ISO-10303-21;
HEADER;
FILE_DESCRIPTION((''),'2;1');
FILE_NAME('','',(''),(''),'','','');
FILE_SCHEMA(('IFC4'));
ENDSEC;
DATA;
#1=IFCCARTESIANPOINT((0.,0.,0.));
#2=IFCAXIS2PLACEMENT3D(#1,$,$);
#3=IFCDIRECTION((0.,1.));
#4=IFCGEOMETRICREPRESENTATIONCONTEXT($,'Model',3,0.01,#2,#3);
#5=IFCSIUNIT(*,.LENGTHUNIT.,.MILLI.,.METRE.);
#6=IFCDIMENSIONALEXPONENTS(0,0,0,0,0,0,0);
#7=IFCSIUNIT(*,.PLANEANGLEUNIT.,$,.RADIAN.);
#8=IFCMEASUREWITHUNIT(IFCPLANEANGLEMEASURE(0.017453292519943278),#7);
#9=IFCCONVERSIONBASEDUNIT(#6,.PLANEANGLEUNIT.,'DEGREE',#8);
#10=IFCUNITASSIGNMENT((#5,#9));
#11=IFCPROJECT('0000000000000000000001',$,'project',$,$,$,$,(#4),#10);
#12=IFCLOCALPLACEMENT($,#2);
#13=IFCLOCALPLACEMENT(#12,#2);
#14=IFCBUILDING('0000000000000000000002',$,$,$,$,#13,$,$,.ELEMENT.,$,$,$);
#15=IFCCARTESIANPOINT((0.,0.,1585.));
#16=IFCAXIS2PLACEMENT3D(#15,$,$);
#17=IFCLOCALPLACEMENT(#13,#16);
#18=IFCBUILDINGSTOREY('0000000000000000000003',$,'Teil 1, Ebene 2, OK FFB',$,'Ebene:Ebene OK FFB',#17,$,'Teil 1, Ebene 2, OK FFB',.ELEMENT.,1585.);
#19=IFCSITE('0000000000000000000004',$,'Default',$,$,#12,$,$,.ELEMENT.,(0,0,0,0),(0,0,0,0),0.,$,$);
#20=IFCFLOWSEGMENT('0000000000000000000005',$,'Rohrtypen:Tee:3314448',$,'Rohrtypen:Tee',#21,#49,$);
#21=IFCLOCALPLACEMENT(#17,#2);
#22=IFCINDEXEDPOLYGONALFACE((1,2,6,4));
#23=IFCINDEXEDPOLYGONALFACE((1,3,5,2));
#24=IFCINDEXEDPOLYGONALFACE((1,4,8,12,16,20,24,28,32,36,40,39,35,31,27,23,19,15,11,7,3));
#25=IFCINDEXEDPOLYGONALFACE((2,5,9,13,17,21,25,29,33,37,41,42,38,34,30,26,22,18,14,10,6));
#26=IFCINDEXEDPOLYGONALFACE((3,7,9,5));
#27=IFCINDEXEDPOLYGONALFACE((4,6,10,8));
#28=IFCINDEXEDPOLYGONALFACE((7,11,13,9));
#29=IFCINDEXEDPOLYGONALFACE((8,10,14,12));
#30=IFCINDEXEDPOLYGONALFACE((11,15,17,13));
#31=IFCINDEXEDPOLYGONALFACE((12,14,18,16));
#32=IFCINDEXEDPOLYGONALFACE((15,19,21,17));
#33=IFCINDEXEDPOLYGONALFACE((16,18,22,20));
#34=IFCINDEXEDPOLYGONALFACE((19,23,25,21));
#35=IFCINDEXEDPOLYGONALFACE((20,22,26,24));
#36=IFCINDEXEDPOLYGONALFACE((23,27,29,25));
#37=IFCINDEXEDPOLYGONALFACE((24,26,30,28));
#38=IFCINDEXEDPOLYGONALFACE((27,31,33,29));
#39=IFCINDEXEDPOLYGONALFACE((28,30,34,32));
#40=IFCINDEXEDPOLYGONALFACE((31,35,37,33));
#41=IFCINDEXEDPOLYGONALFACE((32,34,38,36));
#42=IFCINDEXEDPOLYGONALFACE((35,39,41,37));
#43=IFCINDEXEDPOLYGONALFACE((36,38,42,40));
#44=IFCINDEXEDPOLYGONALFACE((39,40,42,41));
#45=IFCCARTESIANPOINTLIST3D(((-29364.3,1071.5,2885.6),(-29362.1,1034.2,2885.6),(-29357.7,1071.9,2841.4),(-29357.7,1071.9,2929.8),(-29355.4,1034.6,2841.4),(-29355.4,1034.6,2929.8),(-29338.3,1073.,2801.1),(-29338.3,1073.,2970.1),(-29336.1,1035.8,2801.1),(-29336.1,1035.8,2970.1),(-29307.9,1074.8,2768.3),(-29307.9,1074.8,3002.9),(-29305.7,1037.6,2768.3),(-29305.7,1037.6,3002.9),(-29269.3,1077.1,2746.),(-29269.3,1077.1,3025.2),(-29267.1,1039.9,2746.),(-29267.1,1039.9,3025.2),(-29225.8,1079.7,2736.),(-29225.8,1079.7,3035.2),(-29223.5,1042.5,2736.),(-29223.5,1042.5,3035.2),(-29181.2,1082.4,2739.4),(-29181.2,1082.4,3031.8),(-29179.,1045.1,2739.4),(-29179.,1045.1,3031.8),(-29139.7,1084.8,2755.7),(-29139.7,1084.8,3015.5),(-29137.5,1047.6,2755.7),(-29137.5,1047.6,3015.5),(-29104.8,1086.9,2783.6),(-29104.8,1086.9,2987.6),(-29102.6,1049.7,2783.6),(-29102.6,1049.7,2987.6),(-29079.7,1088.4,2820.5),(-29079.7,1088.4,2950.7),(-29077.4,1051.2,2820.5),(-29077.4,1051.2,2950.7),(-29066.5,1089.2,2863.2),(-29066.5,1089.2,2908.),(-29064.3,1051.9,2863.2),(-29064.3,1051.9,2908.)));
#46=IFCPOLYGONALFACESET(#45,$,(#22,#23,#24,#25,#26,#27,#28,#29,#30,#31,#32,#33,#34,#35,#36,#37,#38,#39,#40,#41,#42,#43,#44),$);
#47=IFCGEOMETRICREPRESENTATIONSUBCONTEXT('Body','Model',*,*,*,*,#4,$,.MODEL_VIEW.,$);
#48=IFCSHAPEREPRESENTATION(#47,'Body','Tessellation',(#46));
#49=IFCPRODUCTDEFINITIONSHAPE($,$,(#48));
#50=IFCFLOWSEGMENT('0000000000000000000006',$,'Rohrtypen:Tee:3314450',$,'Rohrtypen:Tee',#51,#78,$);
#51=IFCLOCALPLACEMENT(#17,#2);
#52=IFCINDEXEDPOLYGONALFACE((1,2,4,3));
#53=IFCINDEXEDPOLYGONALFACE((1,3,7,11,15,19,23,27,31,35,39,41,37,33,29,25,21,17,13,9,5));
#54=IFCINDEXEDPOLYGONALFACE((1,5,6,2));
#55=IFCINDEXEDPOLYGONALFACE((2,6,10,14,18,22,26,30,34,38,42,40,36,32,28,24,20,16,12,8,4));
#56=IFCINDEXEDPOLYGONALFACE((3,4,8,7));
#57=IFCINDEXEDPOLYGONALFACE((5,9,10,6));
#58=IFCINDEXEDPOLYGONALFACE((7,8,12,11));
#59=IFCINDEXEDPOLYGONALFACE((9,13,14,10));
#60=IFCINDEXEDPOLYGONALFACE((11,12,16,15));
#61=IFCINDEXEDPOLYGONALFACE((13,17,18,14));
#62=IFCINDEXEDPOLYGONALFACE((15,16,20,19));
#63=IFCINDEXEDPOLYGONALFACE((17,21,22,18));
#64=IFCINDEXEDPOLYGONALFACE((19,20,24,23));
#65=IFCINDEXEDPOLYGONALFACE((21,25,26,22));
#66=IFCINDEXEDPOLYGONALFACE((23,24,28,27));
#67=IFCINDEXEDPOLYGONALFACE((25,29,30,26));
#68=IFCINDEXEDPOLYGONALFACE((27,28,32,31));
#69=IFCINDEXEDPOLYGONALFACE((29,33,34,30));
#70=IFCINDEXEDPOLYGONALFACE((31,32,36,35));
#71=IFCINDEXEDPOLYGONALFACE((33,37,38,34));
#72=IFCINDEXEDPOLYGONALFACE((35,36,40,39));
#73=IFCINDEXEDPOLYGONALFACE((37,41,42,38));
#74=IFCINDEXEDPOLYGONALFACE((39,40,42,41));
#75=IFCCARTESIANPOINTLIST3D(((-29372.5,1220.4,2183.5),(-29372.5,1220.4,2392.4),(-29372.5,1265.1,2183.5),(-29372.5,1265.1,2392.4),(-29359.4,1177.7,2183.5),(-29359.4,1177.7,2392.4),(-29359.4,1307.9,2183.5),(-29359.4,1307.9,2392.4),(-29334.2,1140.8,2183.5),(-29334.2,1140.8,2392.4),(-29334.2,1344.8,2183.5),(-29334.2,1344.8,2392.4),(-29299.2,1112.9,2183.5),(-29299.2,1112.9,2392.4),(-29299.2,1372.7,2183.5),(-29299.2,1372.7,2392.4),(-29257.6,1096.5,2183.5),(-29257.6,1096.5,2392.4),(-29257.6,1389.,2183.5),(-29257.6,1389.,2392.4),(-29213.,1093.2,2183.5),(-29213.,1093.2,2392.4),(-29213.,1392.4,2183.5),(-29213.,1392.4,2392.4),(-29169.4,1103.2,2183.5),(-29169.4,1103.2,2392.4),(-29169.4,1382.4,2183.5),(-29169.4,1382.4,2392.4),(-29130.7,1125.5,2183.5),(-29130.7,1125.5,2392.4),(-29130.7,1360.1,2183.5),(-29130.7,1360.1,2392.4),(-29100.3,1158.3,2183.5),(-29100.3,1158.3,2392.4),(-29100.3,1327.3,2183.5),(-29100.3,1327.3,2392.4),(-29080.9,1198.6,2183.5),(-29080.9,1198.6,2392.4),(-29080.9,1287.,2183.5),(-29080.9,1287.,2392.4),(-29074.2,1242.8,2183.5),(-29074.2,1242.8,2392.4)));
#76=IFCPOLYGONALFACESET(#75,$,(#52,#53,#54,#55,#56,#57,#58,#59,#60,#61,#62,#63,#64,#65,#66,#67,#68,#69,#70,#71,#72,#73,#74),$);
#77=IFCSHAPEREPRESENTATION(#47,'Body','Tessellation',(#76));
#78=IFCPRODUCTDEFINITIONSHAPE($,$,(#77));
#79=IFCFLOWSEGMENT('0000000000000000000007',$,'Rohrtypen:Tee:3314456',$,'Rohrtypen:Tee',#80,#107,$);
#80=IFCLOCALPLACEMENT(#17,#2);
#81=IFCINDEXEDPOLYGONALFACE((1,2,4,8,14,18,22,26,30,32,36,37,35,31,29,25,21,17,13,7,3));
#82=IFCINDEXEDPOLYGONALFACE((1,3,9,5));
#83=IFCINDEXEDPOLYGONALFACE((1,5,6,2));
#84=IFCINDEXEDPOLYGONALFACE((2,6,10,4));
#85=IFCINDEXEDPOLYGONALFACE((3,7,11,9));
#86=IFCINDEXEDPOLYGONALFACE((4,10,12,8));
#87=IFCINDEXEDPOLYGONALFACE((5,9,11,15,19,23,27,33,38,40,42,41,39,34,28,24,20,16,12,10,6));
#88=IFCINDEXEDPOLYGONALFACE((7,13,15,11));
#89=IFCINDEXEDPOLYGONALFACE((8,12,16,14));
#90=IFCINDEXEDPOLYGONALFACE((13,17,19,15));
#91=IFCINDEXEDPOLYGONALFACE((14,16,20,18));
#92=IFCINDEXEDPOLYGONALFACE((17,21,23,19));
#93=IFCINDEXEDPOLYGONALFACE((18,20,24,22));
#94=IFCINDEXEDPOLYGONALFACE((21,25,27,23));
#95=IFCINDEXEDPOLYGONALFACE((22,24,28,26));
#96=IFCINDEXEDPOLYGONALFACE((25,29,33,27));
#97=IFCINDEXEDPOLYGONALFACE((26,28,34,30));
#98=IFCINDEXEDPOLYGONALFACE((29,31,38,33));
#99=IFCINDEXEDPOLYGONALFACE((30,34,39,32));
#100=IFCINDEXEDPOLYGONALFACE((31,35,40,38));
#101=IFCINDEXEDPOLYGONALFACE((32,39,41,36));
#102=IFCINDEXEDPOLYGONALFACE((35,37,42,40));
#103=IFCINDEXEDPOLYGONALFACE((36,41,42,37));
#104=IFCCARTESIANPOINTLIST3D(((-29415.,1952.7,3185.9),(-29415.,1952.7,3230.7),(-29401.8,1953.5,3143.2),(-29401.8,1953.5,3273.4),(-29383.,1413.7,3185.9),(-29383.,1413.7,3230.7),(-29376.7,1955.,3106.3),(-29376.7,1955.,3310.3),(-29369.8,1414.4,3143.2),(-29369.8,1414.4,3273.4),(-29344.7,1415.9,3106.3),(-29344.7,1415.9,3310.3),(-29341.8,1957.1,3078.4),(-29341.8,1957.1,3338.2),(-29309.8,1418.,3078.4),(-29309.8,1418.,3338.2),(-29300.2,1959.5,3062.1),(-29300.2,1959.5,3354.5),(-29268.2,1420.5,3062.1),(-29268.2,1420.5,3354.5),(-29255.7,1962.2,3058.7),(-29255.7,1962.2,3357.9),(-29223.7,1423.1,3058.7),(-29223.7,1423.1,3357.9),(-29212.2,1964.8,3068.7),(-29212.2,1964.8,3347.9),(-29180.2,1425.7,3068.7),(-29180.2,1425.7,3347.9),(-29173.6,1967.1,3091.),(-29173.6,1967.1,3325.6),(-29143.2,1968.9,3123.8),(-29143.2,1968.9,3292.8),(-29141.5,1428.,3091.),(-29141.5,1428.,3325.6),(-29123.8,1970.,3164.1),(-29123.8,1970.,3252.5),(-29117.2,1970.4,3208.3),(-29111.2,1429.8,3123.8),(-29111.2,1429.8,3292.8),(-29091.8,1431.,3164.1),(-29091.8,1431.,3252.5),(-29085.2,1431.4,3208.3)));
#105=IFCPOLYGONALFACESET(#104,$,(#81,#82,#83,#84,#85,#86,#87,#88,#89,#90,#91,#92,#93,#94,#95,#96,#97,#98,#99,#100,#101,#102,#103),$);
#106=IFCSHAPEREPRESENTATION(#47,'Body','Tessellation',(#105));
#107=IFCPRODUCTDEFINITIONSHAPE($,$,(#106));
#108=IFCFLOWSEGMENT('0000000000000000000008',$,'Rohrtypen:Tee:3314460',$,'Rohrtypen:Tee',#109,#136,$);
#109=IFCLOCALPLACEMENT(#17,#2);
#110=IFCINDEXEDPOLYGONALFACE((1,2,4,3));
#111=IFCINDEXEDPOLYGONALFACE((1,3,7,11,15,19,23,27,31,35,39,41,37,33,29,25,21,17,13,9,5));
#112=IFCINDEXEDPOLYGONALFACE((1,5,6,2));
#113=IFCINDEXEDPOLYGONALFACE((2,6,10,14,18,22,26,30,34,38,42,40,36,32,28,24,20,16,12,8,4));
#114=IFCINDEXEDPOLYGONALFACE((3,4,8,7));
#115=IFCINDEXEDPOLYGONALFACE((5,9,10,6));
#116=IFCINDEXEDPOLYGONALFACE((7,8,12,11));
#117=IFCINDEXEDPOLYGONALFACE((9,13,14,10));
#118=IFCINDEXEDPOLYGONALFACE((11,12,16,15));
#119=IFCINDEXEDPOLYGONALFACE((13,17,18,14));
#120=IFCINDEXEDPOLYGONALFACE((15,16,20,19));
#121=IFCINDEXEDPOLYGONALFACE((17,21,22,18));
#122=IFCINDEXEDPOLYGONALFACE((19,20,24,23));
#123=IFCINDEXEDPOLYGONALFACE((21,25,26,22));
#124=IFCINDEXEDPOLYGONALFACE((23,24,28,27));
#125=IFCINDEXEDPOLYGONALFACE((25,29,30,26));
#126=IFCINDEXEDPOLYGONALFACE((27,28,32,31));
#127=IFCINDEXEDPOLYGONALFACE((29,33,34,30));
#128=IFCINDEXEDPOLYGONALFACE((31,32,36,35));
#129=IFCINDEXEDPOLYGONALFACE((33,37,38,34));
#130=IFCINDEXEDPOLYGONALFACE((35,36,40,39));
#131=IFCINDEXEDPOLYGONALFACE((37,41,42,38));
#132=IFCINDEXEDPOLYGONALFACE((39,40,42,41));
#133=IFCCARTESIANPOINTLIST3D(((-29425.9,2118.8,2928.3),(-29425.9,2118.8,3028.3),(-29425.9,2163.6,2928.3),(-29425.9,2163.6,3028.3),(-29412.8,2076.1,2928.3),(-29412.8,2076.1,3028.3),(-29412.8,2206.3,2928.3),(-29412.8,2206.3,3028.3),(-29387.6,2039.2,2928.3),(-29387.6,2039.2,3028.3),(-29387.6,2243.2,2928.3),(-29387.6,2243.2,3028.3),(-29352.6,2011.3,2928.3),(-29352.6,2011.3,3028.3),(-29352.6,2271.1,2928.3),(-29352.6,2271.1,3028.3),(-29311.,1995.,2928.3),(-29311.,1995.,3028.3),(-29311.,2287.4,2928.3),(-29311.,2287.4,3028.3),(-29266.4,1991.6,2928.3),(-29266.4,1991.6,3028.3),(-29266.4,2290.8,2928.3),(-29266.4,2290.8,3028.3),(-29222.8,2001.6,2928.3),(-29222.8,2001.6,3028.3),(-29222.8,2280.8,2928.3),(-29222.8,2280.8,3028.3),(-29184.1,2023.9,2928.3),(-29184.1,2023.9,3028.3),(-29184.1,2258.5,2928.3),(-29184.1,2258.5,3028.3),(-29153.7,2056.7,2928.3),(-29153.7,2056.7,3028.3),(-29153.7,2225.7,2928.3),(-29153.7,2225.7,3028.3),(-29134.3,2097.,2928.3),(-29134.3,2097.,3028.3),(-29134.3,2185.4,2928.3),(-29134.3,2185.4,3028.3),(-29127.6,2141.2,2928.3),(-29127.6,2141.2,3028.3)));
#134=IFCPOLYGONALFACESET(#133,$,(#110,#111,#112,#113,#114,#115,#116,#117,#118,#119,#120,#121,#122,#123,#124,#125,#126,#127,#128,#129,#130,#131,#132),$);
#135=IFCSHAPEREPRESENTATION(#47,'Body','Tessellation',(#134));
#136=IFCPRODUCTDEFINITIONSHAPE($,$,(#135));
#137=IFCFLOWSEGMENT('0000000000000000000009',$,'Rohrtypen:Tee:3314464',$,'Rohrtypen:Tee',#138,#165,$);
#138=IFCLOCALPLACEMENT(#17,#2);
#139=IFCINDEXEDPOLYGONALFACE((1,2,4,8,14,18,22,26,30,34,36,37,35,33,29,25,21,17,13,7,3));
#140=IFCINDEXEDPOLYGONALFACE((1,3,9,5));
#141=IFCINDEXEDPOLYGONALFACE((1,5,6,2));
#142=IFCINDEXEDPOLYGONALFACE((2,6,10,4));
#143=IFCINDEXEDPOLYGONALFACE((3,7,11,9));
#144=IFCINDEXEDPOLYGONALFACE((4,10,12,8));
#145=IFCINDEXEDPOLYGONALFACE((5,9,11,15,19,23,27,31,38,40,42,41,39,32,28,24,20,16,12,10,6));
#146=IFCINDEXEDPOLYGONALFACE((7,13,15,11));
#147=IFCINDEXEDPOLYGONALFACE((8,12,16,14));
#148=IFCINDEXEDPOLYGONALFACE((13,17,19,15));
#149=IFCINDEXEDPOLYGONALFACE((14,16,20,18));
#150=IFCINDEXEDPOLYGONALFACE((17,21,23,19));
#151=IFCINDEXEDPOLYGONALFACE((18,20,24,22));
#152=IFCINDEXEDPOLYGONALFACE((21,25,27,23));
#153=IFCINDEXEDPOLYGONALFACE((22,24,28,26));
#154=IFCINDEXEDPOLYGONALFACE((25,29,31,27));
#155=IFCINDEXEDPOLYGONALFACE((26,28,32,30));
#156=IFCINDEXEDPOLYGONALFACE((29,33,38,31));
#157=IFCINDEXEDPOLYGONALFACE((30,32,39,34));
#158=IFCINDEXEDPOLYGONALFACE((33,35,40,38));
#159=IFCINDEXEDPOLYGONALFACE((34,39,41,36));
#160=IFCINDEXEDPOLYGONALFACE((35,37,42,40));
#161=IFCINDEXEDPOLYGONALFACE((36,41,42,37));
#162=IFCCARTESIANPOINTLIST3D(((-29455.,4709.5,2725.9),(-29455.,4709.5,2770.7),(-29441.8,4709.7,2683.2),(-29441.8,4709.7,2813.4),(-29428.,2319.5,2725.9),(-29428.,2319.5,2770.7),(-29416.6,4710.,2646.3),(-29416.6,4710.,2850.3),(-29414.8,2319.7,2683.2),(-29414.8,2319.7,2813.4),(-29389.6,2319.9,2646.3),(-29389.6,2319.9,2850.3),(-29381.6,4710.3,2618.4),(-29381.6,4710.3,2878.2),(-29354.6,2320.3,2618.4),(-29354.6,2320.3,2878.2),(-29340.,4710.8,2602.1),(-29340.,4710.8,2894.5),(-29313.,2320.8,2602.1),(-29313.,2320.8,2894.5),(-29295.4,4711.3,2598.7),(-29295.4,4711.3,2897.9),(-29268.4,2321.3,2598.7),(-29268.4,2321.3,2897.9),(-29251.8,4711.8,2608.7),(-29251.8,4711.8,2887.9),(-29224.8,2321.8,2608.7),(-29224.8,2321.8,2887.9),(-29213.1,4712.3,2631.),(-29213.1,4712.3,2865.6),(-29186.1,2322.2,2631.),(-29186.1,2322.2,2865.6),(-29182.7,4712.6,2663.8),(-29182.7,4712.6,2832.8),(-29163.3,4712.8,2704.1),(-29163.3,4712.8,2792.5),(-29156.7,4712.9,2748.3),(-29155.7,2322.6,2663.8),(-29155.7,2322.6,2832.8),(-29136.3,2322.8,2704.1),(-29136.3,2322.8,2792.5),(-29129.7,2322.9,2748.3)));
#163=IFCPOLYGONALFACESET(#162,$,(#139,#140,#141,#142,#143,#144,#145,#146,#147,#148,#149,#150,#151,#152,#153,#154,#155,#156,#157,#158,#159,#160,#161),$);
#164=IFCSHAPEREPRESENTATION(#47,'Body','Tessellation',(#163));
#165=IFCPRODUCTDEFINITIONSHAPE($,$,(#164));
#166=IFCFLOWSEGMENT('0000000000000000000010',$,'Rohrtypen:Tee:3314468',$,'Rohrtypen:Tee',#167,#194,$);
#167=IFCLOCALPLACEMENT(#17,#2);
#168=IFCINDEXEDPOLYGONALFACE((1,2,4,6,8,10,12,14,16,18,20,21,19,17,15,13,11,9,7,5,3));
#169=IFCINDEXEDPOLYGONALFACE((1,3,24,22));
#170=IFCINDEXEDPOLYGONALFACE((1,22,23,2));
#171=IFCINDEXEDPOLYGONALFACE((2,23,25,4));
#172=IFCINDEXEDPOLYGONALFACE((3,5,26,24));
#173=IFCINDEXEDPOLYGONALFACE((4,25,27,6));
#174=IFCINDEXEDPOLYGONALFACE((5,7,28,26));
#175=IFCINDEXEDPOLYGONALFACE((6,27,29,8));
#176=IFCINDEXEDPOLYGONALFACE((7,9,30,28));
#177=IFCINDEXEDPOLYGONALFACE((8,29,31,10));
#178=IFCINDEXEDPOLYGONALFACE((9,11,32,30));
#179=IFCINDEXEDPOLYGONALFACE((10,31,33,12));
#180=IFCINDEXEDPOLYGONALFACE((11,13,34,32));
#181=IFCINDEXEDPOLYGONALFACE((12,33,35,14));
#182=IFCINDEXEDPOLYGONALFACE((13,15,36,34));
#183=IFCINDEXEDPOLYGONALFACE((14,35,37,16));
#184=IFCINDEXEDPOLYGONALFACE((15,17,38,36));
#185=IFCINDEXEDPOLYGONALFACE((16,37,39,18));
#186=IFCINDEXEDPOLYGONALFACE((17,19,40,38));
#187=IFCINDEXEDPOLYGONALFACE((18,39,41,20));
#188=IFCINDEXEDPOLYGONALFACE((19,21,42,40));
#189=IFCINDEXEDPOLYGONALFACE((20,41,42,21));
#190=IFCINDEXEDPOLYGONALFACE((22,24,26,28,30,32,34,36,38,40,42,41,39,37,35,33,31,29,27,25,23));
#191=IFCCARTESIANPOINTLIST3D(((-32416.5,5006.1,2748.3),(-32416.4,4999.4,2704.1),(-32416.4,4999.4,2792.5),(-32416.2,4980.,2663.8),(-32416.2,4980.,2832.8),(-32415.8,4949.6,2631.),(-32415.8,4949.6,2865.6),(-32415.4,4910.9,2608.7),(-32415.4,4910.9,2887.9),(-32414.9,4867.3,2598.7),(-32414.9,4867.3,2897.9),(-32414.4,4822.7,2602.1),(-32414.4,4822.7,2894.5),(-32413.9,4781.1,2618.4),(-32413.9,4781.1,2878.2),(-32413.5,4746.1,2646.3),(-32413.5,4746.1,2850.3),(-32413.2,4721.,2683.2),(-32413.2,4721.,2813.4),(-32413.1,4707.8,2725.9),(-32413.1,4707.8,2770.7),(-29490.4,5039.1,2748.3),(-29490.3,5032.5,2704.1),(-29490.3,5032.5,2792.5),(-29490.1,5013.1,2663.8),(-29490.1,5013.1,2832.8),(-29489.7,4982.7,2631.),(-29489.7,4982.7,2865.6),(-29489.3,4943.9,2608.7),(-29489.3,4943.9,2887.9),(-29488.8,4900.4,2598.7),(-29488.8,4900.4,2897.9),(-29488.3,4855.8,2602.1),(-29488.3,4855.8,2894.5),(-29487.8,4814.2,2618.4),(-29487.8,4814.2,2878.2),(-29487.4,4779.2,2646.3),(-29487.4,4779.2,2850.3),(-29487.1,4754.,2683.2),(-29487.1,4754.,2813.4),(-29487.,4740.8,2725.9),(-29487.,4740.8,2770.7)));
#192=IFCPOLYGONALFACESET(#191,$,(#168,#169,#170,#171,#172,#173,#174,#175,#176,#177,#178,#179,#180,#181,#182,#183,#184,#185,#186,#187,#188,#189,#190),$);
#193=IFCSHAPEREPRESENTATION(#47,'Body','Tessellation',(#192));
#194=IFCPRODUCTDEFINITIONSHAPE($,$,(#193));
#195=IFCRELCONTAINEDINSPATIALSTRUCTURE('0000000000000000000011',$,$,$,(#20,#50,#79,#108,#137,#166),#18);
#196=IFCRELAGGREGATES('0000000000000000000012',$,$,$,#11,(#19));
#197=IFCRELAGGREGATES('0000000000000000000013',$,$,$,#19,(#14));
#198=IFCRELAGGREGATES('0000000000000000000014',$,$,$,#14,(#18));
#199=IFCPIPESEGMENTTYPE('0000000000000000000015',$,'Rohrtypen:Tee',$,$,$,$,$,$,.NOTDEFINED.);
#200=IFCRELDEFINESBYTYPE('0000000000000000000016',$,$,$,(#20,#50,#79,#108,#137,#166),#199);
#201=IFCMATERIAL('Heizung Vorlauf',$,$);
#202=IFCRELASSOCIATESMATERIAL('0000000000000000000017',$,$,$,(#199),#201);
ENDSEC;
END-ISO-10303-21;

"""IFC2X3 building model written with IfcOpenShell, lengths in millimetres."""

from ifc_helpers import new_model, entity, si_unit, converted_unit, direction, frame, frame_2d, origin, origin_2d_with_axis, place, context, subcontext, project, spatial, circle, extrude, material, type_object, element, save


model = new_model("IFC2X3")

# Units and contexts
model_context = context("Model", 3, precision=0.01, world=origin(), true_north=direction((0.0, 1.0)))
body_context = subcontext(model_context, "Body", "Model", "MODEL_VIEW")
ifc_project = project(units=[si_unit("LENGTHUNIT", "METRE", prefix="MILLI"), converted_unit("PLANEANGLEUNIT", "DEGREE", entity("IfcPlaneAngleMeasure", 0.017453292519943278), si_unit("PLANEANGLEUNIT", "RADIAN"), dimensions=[0, 0, 0, 0, 0, 0, 0])], contexts=[model_context])

# Site, building, storey
site_placement = place(None, origin())
site = spatial("IfcSite", under=ifc_project, at=site_placement, Name="Default", CompositionType="ELEMENT", RefLatitude=(0, 0, 0, 0), RefLongitude=(0, 0, 0, 0), RefElevation=0.0)
building_placement = place(site_placement, origin())
building = spatial("IfcBuilding", under=site, at=building_placement, CompositionType="ELEMENT")
storey_placement = place(building_placement, frame((0.0, 0.0, 1585.0)))
storey = spatial("IfcBuildingStorey", under=building, at=storey_placement, Name="Teil 1, Ebene 2, OK FFB", ObjectType="Ebene:Ebene OK FFB", LongName="Teil 1, Ebene 2, OK FFB", CompositionType="ELEMENT", Elevation=1585.0)

# Flow segments
ifc_material = material(Name="Heizung Vorlauf")
pipe_segment_type = type_object("IfcPipeSegmentType", Name="Rohrtypen:Tee", PredefinedType="NOTDEFINED", material=ifc_material)
flow_segment_1_placement = place(storey_placement, origin())
element("IfcFlowSegment", 1, at=flow_segment_1_placement, inside=storey, type_object=pipe_segment_type, Name="Rohrtypen:Tee:3314448", ObjectType="Rohrtypen:Tee", context=body_context, shape_type="SweptSolid", body=[
    extrude(circle(Radius=150.0, at=frame_2d((0.0, 0.0), x_axis=(1.0, 0.0))), frame((-29212.4, 1043.1, 2885.6), z_axis=(-0.059319, 0.998239, 0.0), x_axis=(-0.998239, -0.059319, 0.0)), (0.0, 0.0, 1.0), 37.3),
])
flow_segment_2_placement = place(storey_placement, origin())
element("IfcFlowSegment", 2, at=flow_segment_2_placement, inside=storey, type_object=pipe_segment_type, Name="Rohrtypen:Tee:3314450", ObjectType="Rohrtypen:Tee", context=body_context, shape_type="SweptSolid", body=[
    extrude(circle(Radius=150.0, at=origin_2d_with_axis()), frame((-29224.2, 1242.8, 2183.5)), (0.0, 0.0, 1.0), 208.9),
])
flow_segment_3_placement = place(storey_placement, origin())
element("IfcFlowSegment", 3, at=flow_segment_3_placement, inside=storey, type_object=pipe_segment_type, Name="Rohrtypen:Tee:3314456", ObjectType="Rohrtypen:Tee", context=body_context, shape_type="SweptSolid", body=[
    extrude(circle(Radius=150.0, at=frame_2d((0.0, 0.0), x_axis=(1.0, 0.0))), frame((-29234.9, 1422.5, 3208.3), z_axis=(-0.059319, 0.998239, 0.0), x_axis=(0.998239, 0.059319, 0.0)), (0.0, 0.0, 1.0), 540.0),
])
flow_segment_4_placement = place(storey_placement, origin())
element("IfcFlowSegment", 4, at=flow_segment_4_placement, inside=storey, type_object=pipe_segment_type, Name="Rohrtypen:Tee:3314460", ObjectType="Rohrtypen:Tee", context=body_context, shape_type="SweptSolid", body=[
    extrude(circle(Radius=150.0, at=origin_2d_with_axis()), frame((-29277.6, 2141.2, 2928.3)), (0.0, 0.0, 1.0), 100.0),
])
flow_segment_5_placement = place(storey_placement, origin())
element("IfcFlowSegment", 5, at=flow_segment_5_placement, inside=storey, type_object=pipe_segment_type, Name="Rohrtypen:Tee:3314464", ObjectType="Rohrtypen:Tee", context=body_context, shape_type="SweptSolid", body=[
    extrude(circle(Radius=150.0, at=frame_2d((0.0, 0.0), x_axis=(1.0, 0.0))), frame((-29306.6, 4711.2, 2748.3), z_axis=(0.011297, -0.999936, 0.0), x_axis=(0.999936, 0.011297, 0.0)), (0.0, 0.0, 1.0), 2390.2),
])
flow_segment_6_placement = place(storey_placement, origin())
element("IfcFlowSegment", 6, at=flow_segment_6_placement, inside=storey, type_object=pipe_segment_type, Name="Rohrtypen:Tee:3314468", ObjectType="Rohrtypen:Tee", context=body_context, shape_type="SweptSolid", body=[
    extrude(circle(Radius=150.0, at=frame_2d((0.0, 0.0), x_axis=(1.0, 0.0))), frame((-32414.8, 4856.1, 2748.3), z_axis=(0.999936, 0.011297, 0.0), x_axis=(-0.011297, 0.999936, 0.0)), (0.0, 0.0, 1.0), 2926.3),
])

save(model, "model.ifc")
